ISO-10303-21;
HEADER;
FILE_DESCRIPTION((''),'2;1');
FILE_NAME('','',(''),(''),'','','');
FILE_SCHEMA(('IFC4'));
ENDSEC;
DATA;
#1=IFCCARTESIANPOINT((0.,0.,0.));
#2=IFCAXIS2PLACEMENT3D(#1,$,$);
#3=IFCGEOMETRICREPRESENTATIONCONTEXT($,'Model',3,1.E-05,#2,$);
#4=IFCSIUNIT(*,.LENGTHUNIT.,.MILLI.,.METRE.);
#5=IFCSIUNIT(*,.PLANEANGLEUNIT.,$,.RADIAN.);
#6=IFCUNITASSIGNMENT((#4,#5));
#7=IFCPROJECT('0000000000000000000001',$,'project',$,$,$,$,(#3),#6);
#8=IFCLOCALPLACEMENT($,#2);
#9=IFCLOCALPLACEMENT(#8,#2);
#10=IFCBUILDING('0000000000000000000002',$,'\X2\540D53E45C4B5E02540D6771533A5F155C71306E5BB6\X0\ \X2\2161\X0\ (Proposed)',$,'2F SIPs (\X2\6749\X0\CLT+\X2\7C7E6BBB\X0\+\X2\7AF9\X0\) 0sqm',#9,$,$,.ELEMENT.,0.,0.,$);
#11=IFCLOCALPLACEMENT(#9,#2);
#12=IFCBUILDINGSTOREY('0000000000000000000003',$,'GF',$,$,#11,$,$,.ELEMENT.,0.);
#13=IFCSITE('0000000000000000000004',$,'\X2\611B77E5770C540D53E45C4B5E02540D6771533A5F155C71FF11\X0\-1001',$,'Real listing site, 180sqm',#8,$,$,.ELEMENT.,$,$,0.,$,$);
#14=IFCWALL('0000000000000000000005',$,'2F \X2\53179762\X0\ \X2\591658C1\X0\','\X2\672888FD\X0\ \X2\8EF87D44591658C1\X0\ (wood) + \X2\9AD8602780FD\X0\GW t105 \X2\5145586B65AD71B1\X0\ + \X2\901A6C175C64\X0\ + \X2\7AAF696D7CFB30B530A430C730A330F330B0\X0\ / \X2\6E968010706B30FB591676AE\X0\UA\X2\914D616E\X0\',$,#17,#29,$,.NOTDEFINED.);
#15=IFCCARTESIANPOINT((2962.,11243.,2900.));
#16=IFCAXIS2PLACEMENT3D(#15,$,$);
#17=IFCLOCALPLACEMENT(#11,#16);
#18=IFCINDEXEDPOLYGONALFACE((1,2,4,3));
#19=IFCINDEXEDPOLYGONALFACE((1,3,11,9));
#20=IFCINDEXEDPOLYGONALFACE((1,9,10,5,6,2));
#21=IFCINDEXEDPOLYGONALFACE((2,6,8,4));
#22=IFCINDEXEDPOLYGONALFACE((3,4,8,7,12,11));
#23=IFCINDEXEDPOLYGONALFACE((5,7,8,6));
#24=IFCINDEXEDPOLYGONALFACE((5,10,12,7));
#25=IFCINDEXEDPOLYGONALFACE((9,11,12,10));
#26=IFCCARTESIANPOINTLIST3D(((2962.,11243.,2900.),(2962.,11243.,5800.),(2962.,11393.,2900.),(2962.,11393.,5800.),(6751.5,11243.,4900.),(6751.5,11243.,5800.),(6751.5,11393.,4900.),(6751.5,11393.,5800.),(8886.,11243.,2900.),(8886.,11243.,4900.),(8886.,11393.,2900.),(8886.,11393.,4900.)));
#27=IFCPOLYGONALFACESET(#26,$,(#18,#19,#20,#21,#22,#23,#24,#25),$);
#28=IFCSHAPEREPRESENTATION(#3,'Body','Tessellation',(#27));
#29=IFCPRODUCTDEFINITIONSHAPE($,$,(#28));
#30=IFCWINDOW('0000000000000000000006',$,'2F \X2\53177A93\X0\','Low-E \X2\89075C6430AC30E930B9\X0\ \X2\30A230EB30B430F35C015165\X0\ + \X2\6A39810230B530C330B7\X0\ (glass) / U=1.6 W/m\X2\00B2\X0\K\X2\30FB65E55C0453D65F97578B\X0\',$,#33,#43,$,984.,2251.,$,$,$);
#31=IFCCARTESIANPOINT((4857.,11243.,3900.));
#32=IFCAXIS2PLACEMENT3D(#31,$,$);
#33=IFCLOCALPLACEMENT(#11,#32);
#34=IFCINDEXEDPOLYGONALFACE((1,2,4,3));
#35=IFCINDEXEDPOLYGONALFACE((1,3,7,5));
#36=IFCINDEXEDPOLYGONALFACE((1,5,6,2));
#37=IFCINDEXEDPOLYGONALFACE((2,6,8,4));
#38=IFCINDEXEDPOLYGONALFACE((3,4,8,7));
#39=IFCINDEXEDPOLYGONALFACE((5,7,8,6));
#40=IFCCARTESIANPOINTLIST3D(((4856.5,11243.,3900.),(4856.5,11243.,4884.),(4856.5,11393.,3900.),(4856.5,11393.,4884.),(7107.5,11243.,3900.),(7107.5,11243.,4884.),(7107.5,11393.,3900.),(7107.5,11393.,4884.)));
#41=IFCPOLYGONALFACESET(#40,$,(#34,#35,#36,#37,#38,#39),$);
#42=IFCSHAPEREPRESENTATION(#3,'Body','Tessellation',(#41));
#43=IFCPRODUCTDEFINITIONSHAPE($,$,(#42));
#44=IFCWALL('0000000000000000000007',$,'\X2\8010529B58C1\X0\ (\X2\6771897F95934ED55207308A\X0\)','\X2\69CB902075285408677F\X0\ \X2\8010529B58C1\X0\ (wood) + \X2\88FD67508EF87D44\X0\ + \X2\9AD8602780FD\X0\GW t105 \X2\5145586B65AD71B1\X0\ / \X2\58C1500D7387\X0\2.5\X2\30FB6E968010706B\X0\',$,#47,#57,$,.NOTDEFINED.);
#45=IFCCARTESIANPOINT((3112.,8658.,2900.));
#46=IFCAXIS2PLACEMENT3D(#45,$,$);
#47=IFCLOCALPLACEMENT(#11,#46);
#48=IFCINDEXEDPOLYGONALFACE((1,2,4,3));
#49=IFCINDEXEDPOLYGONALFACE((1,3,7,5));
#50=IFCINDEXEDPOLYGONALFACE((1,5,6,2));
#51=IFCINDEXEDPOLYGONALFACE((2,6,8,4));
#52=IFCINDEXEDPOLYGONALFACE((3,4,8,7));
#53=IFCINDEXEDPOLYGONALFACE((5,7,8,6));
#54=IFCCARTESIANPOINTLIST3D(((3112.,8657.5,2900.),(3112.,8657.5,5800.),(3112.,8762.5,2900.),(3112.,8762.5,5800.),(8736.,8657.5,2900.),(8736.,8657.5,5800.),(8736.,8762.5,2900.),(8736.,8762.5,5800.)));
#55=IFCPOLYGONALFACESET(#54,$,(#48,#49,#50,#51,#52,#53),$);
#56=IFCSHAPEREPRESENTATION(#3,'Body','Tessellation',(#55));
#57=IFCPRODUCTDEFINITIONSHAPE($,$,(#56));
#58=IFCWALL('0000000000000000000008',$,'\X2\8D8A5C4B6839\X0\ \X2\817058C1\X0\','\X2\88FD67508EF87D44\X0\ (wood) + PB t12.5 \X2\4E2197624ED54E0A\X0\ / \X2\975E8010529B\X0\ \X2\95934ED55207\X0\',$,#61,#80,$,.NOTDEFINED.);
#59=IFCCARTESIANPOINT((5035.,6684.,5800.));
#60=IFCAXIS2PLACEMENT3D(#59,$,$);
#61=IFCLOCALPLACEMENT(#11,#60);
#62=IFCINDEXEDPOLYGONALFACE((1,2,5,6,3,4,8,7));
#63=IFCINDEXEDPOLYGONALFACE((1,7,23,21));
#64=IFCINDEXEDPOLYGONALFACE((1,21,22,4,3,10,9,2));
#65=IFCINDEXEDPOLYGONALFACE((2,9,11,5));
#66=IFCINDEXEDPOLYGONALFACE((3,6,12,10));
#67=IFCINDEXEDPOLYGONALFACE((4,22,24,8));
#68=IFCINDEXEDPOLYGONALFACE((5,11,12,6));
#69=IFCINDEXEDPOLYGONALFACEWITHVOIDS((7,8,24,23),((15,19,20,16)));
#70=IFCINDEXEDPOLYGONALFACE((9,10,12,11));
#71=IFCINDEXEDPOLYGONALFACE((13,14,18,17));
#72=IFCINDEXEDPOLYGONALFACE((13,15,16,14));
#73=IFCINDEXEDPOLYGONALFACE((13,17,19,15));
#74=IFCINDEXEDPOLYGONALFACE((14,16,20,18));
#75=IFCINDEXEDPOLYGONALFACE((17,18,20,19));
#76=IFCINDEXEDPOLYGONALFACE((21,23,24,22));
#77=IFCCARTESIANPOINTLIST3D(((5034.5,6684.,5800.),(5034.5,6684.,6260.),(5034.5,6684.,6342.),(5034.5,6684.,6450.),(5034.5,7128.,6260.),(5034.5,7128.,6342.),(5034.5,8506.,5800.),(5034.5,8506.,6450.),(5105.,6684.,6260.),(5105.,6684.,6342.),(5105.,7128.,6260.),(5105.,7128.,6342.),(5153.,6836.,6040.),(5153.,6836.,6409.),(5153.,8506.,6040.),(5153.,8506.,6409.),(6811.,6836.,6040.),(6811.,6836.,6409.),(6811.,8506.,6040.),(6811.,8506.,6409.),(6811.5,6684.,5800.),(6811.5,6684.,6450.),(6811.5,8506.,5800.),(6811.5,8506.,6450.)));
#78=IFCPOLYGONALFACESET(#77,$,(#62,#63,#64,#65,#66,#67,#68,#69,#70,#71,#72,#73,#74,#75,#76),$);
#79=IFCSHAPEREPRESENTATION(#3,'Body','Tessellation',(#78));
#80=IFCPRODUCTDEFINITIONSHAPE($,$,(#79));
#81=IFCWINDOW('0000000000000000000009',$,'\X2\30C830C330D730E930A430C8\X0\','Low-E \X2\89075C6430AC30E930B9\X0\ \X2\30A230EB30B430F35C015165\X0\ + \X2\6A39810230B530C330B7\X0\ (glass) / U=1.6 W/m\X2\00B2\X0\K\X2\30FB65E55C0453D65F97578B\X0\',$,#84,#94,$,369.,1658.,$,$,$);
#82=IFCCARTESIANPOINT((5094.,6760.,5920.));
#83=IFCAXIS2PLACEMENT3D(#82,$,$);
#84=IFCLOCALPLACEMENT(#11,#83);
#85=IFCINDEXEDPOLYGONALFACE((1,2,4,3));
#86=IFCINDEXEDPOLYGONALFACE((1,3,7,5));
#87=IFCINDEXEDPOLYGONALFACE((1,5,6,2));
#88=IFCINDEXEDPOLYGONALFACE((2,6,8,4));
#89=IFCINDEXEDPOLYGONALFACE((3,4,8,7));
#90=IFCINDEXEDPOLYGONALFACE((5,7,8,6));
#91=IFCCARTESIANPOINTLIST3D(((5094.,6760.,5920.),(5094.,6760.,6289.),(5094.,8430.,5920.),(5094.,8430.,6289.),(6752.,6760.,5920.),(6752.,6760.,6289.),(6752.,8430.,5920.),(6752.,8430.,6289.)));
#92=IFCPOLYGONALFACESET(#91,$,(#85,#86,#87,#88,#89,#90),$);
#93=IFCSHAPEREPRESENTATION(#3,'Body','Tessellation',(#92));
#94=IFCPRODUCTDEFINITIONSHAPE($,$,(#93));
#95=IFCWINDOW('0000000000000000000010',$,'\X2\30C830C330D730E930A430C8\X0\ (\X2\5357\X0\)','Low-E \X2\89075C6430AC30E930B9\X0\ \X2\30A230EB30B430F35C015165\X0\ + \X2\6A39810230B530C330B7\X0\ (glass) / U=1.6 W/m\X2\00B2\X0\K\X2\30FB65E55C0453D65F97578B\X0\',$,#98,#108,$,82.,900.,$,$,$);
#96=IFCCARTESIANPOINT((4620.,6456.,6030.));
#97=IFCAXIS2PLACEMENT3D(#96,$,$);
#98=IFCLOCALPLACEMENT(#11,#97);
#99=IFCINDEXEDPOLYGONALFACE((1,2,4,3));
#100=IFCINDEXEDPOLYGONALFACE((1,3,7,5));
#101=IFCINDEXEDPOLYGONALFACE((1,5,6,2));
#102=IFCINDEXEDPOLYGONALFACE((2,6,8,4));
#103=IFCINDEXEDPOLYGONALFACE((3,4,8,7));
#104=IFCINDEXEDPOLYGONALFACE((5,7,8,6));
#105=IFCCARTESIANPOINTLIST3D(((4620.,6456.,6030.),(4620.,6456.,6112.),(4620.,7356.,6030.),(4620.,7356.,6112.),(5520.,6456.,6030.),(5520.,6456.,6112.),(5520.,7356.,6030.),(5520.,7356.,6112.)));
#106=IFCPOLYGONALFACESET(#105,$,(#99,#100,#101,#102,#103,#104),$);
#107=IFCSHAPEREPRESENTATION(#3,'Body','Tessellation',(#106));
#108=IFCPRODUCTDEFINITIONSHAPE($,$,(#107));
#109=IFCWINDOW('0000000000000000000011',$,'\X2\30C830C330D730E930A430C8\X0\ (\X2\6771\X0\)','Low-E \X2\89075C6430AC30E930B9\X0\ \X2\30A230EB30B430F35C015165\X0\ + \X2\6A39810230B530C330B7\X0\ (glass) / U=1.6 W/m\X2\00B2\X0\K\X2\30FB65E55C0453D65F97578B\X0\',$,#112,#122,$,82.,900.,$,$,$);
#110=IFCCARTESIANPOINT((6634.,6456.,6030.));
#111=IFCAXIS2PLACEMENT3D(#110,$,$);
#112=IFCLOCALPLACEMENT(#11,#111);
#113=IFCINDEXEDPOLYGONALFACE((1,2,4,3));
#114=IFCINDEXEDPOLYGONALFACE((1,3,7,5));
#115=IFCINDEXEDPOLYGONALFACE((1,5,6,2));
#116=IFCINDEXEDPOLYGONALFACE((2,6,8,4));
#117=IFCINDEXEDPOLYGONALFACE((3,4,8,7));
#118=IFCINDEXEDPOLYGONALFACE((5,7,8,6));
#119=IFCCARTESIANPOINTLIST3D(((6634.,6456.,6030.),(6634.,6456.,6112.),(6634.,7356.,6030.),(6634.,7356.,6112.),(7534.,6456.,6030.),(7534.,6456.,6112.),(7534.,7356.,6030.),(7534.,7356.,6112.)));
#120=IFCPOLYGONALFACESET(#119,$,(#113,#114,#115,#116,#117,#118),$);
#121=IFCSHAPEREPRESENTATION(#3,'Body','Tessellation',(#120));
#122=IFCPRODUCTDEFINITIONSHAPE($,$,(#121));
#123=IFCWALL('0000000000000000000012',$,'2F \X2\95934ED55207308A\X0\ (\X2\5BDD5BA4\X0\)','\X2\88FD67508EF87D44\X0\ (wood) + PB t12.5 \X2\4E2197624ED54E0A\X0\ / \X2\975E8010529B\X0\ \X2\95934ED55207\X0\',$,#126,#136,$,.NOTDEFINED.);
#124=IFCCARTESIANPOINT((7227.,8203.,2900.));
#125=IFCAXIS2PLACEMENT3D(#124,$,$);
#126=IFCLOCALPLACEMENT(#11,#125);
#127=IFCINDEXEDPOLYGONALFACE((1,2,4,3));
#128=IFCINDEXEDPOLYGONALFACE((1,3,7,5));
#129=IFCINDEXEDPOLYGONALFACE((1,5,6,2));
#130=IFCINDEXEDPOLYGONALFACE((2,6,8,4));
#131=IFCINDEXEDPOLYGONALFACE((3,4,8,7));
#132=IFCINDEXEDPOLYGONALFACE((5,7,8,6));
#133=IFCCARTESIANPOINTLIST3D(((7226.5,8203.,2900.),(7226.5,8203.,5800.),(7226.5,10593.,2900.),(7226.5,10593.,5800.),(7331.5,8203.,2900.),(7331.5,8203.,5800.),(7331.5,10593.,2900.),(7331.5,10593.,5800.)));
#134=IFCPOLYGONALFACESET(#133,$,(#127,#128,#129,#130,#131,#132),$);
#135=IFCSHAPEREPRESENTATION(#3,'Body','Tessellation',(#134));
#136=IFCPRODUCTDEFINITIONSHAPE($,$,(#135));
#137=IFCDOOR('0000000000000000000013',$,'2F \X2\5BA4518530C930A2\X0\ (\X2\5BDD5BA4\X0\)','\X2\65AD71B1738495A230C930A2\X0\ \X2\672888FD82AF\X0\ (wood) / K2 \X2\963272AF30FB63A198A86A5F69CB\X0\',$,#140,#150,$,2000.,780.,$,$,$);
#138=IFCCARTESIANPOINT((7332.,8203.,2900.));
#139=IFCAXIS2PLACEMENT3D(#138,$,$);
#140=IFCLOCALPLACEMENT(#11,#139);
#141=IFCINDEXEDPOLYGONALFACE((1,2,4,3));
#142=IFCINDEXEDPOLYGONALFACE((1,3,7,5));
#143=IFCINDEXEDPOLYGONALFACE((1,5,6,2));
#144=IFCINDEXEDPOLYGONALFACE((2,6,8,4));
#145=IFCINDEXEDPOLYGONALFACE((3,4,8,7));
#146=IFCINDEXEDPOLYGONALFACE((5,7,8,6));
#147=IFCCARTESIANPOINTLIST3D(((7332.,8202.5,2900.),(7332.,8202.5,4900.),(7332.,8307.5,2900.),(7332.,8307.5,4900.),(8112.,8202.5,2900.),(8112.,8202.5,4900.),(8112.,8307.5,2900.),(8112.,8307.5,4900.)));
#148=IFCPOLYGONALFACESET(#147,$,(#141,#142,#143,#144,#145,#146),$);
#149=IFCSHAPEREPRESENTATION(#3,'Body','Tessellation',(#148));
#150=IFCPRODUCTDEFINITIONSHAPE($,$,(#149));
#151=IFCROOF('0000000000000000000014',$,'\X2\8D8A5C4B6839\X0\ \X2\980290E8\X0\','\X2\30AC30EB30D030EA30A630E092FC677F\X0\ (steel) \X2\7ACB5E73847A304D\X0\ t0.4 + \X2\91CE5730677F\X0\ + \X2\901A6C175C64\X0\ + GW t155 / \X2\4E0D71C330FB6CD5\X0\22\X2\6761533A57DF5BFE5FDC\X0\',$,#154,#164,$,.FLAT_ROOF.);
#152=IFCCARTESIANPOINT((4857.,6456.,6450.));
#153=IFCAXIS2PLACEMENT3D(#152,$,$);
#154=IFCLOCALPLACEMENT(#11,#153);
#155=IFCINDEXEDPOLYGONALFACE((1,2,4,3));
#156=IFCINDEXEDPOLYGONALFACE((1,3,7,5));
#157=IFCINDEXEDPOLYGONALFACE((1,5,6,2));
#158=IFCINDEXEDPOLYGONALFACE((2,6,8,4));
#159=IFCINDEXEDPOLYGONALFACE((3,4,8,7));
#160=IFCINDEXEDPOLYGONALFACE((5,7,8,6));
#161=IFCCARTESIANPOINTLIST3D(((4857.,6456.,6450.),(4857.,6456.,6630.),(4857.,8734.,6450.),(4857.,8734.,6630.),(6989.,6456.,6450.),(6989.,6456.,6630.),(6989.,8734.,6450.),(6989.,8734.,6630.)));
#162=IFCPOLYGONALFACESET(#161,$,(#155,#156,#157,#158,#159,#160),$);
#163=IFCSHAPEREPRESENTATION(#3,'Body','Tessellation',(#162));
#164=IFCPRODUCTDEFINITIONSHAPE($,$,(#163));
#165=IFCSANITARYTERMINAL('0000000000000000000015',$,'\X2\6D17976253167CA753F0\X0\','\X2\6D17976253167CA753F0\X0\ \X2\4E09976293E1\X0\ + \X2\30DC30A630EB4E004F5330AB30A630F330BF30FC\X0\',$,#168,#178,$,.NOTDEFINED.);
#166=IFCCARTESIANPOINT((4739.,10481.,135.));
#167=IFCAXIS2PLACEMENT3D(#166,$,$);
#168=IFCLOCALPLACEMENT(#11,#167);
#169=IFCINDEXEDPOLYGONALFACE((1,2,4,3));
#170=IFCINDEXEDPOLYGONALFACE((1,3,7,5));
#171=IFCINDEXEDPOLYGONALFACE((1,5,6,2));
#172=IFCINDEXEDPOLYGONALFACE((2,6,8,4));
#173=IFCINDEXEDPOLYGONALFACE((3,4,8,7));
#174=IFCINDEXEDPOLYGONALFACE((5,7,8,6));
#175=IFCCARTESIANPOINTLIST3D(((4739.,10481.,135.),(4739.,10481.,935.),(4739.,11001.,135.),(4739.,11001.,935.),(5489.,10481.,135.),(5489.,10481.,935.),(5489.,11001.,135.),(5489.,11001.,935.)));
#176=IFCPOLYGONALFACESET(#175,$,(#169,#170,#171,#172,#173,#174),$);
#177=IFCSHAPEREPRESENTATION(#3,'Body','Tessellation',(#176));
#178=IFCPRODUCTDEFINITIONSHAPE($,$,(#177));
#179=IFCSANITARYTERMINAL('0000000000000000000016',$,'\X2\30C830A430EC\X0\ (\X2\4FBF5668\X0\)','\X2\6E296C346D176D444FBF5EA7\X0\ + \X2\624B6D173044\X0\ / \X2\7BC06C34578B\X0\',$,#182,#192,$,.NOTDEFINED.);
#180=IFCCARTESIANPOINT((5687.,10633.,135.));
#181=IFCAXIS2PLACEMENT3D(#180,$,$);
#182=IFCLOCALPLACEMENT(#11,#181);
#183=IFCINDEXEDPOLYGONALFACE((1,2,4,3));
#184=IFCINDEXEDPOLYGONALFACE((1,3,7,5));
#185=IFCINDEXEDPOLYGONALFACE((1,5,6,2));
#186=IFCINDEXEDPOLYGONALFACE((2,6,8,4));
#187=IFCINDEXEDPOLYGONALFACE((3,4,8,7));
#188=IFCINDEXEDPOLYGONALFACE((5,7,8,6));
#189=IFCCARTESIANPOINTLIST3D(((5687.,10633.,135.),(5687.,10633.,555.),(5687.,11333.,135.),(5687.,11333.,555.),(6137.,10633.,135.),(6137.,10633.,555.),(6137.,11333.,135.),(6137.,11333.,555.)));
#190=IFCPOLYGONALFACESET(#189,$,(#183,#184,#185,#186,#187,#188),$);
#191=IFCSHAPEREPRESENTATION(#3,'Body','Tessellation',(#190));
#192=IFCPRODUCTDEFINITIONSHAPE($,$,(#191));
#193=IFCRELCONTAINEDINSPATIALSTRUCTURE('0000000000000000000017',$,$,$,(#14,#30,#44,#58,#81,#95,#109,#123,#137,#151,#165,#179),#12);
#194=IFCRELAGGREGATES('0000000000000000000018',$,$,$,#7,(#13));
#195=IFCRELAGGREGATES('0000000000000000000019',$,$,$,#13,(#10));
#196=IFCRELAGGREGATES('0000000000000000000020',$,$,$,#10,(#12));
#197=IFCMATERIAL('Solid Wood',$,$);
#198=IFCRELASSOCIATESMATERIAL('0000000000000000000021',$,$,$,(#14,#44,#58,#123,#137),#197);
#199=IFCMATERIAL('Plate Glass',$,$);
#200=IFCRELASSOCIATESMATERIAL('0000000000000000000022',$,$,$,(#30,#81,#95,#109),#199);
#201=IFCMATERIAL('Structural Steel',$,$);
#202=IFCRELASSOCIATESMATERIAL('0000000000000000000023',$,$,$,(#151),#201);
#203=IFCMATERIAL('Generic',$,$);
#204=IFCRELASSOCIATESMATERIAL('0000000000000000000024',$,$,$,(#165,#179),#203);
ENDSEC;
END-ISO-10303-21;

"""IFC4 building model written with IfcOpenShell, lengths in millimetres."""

from ifc_helpers import new_model, si_unit, frame, frame_2d, origin, place, context, project, spatial, rectangle, extrude, material, element, fill, save


model = new_model("IFC4")

# Units and contexts
model_context = context("Model", 3, precision=1e-05, world=origin())
ifc_project = project(units=[si_unit("LENGTHUNIT", "METRE", prefix="MILLI"), si_unit("PLANEANGLEUNIT", "RADIAN")], contexts=[model_context])

# Site, building, storey
site_placement = place(None, origin())
site = spatial("IfcSite", under=ifc_project, at=site_placement, Name="愛知県名古屋市名東区引山１-1001", ObjectType="Real listing site, 180sqm", CompositionType="ELEMENT", RefElevation=0.0)
building_placement = place(site_placement, origin())
building = spatial("IfcBuilding", under=site, at=building_placement, Name="名古屋市名東区引山の家 Ⅱ (Proposed)", ObjectType="2F SIPs (杉CLT+籾殻+竹) 0sqm", CompositionType="ELEMENT", ElevationOfRefHeight=0.0, ElevationOfTerrain=0.0)
storey_placement = place(building_placement, origin())
storey = spatial("IfcBuildingStorey", under=building, at=storey_placement, Name="GF", CompositionType="ELEMENT", Elevation=0.0)

# Wall, opening, window
ifc_material_1 = material(Name="Solid Wood")
wall_1_placement = place(storey_placement, frame((2962.0, 11243.0, 2900.0)))
wall_1 = element("IfcWall", 1, at=wall_1_placement, inside=storey, material=ifc_material_1, Name="2F 北面 外壁", Description="木製 軸組外壁 (wood) + 高性能GW t105 充填断熱 + 通気層 + 窯業系サイディング / 準耐火・外皮UA配慮", PredefinedType="NOTDEFINED", context=model_context, shape_type="SweptSolid", body=[
    extrude(rectangle(XDim=5924.0, YDim=150.0, at=frame_2d((2962.0, 75.0))), frame((2962.0, 11243.0, 2900.0)), (0.0, 0.0, 1.0), 2900.0),
])
opening_1_placement = place(storey_placement, frame((4857.0, 11243.0, 3900.0)))
opening_1 = element("IfcOpeningElement", 2, at=opening_1_placement, cuts=wall_1, PredefinedType="NOTDEFINED", context=model_context, shape_type="SweptSolid", body=[
    extrude(rectangle(XDim=2251.0, YDim=150.0, at=frame_2d((1125.0, 75.0))), frame((4857.0, 11243.0, 3900.0)), (0.0, 0.0, 1.0), 984.0),
])
ifc_material_2 = material(Name="Plate Glass")
window_1_placement = place(storey_placement, frame((4857.0, 11243.0, 3900.0)))
window_1 = element("IfcWindow", 3, at=window_1_placement, inside=storey, material=ifc_material_2, Name="2F 北窓", Description="Low-E 複層ガラス アルゴン封入 + 樹脂サッシ (glass) / U=1.6 W/m²K・日射取得型", OverallHeight=984.0, OverallWidth=2251.0, context=model_context, shape_type="SweptSolid", body=[
    extrude(rectangle(XDim=2251.0, YDim=150.0, at=frame_2d((1125.0, 75.0))), frame((4857.0, 11243.0, 3900.0)), (0.0, 0.0, 1.0), 984.0),
])
fill(opening_1, window_1)

# Wall
wall_2_placement = place(storey_placement, frame((3112.0, 8658.0, 2900.0)))
element("IfcWall", 4, at=wall_2_placement, inside=storey, material=ifc_material_1, Name="耐力壁 (東西間仕切り)", Description="構造用合板 耐力壁 (wood) + 製材軸組 + 高性能GW t105 充填断熱 / 壁倍率2.5・準耐火", PredefinedType="NOTDEFINED", context=model_context, shape_type="SweptSolid", body=[
    extrude(rectangle(XDim=5624.0, YDim=105.0, at=frame_2d((2812.0, 52.0))), frame((3112.0, 8658.0, 2900.0)), (0.0, 0.0, 1.0), 2900.0),
])

# Wall, openings, windows
wall_3_placement = place(storey_placement, frame((5035.0, 6684.0, 5800.0)))
wall_3 = element("IfcWall", 5, at=wall_3_placement, inside=storey, material=ifc_material_1, Name="越屋根 腰壁", Description="製材軸組 (wood) + PB t12.5 両面仕上 / 非耐力 間仕切", PredefinedType="NOTDEFINED", context=model_context, shape_type="SweptSolid", body=[
    extrude(rectangle(XDim=1777.0, YDim=1822.0, at=frame_2d((888.0, 911.0))), frame((5035.0, 6684.0, 5800.0)), (0.0, 0.0, 1.0), 650.0),
])
opening_2_placement = place(storey_placement, frame((5094.0, 6760.0, 5920.0)))
opening_2 = element("IfcOpeningElement", 6, at=opening_2_placement, cuts=wall_3, PredefinedType="NOTDEFINED", context=model_context, shape_type="SweptSolid", body=[
    extrude(rectangle(XDim=1658.0, YDim=1670.0, at=frame_2d((829.0, 835.0))), frame((5094.0, 6760.0, 5920.0)), (0.0, 0.0, 1.0), 369.0),
])
opening_3_placement = place(storey_placement, frame((4620.0, 6456.0, 6030.0)))
opening_3 = element("IfcOpeningElement", 7, at=opening_3_placement, cuts=wall_3, PredefinedType="NOTDEFINED", context=model_context, shape_type="SweptSolid", body=[
    extrude(rectangle(XDim=900.0, YDim=900.0, at=frame_2d((450.0, 450.0))), frame((4620.0, 6456.0, 6030.0)), (0.0, 0.0, 1.0), 82.0),
])
opening_4_placement = place(storey_placement, frame((6634.0, 6456.0, 6030.0)))
opening_4 = element("IfcOpeningElement", 8, at=opening_4_placement, cuts=wall_3, PredefinedType="NOTDEFINED", context=model_context, shape_type="SweptSolid", body=[
    extrude(rectangle(XDim=900.0, YDim=900.0, at=frame_2d((450.0, 450.0))), frame((6634.0, 6456.0, 6030.0)), (0.0, 0.0, 1.0), 82.0),
])
window_2_placement = place(storey_placement, frame((5094.0, 6760.0, 5920.0)))
window_2 = element("IfcWindow", 9, at=window_2_placement, inside=storey, material=ifc_material_2, Name="トップライト", Description="Low-E 複層ガラス アルゴン封入 + 樹脂サッシ (glass) / U=1.6 W/m²K・日射取得型", OverallHeight=369.0, OverallWidth=1658.0, context=model_context, shape_type="SweptSolid", body=[
    extrude(rectangle(XDim=1658.0, YDim=1670.0, at=frame_2d((829.0, 835.0))), frame((5094.0, 6760.0, 5920.0)), (0.0, 0.0, 1.0), 369.0),
])
fill(opening_2, window_2)
window_3_placement = place(storey_placement, frame((4620.0, 6456.0, 6030.0)))
window_3 = element("IfcWindow", 10, at=window_3_placement, inside=storey, material=ifc_material_2, Name="トップライト (南)", Description="Low-E 複層ガラス アルゴン封入 + 樹脂サッシ (glass) / U=1.6 W/m²K・日射取得型", OverallHeight=82.0, OverallWidth=900.0, context=model_context, shape_type="SweptSolid", body=[
    extrude(rectangle(XDim=900.0, YDim=900.0, at=frame_2d((450.0, 450.0))), frame((4620.0, 6456.0, 6030.0)), (0.0, 0.0, 1.0), 82.0),
])
fill(opening_3, window_3)
window_4_placement = place(storey_placement, frame((6634.0, 6456.0, 6030.0)))
window_4 = element("IfcWindow", 11, at=window_4_placement, inside=storey, material=ifc_material_2, Name="トップライト (東)", Description="Low-E 複層ガラス アルゴン封入 + 樹脂サッシ (glass) / U=1.6 W/m²K・日射取得型", OverallHeight=82.0, OverallWidth=900.0, context=model_context, shape_type="SweptSolid", body=[
    extrude(rectangle(XDim=900.0, YDim=900.0, at=frame_2d((450.0, 450.0))), frame((6634.0, 6456.0, 6030.0)), (0.0, 0.0, 1.0), 82.0),
])
fill(opening_4, window_4)

# Wall
wall_4_placement = place(storey_placement, frame((7227.0, 8203.0, 2900.0)))
element("IfcWall", 12, at=wall_4_placement, inside=storey, material=ifc_material_1, Name="2F 間仕切り (寝室)", Description="製材軸組 (wood) + PB t12.5 両面仕上 / 非耐力 間仕切", PredefinedType="NOTDEFINED", context=model_context, shape_type="SweptSolid", body=[
    extrude(rectangle(XDim=105.0, YDim=2390.0, at=frame_2d((52.0, 1195.0))), frame((7227.0, 8203.0, 2900.0)), (0.0, 0.0, 1.0), 2900.0),
])

# Door
door_placement = place(storey_placement, frame((7332.0, 8203.0, 2900.0)))
element("IfcDoor", 13, at=door_placement, inside=storey, material=ifc_material_1, Name="2F 室内ドア (寝室)", Description="断熱玄関ドア 木製芯 (wood) / K2 防犯・採風機構", OverallHeight=2000.0, OverallWidth=780.0, context=model_context, shape_type="SweptSolid", body=[
    extrude(rectangle(XDim=780.0, YDim=105.0, at=frame_2d((390.0, 52.0))), frame((7332.0, 8203.0, 2900.0)), (0.0, 0.0, 1.0), 2000.0),
])

# Roof
ifc_material_3 = material(Name="Structural Steel")
roof_placement = place(storey_placement, frame((4857.0, 6456.0, 6450.0)))
element("IfcRoof", 14, at=roof_placement, inside=storey, material=ifc_material_3, Name="越屋根 頂部", Description="ガルバリウム鋼板 (steel) 立平葺き t0.4 + 野地板 + 通気層 + GW t155 / 不燃・法22条区域対応", PredefinedType="FLAT_ROOF", context=model_context, shape_type="SweptSolid", body=[
    extrude(rectangle(XDim=2132.0, YDim=2278.0, at=frame_2d((1066.0, 1139.0))), frame((4857.0, 6456.0, 6450.0)), (0.0, 0.0, 1.0), 180.0),
])

# Sanitary terminals
ifc_material_4 = material(Name="Generic")
sanitary_terminal_1_placement = place(storey_placement, frame((4739.0, 10481.0, 135.0)))
element("IfcSanitaryTerminal", 15, at=sanitary_terminal_1_placement, inside=storey, material=ifc_material_4, Name="洗面化粧台", Description="洗面化粧台 三面鏡 + ボウル一体カウンター", PredefinedType="NOTDEFINED", context=model_context, shape_type="SweptSolid", body=[
    extrude(rectangle(XDim=750.0, YDim=520.0, at=frame_2d((375.0, 260.0))), frame((4739.0, 10481.0, 135.0)), (0.0, 0.0, 1.0), 800.0),
])
sanitary_terminal_2_placement = place(storey_placement, frame((5687.0, 10633.0, 135.0)))
element("IfcSanitaryTerminal", 16, at=sanitary_terminal_2_placement, inside=storey, material=ifc_material_4, Name="トイレ (便器)", Description="温水洗浄便座 + 手洗い / 節水型", PredefinedType="NOTDEFINED", context=model_context, shape_type="SweptSolid", body=[
    extrude(rectangle(XDim=450.0, YDim=700.0, at=frame_2d((225.0, 350.0))), frame((5687.0, 10633.0, 135.0)), (0.0, 0.0, 1.0), 420.0),
])

save(model, "model.ifc")
